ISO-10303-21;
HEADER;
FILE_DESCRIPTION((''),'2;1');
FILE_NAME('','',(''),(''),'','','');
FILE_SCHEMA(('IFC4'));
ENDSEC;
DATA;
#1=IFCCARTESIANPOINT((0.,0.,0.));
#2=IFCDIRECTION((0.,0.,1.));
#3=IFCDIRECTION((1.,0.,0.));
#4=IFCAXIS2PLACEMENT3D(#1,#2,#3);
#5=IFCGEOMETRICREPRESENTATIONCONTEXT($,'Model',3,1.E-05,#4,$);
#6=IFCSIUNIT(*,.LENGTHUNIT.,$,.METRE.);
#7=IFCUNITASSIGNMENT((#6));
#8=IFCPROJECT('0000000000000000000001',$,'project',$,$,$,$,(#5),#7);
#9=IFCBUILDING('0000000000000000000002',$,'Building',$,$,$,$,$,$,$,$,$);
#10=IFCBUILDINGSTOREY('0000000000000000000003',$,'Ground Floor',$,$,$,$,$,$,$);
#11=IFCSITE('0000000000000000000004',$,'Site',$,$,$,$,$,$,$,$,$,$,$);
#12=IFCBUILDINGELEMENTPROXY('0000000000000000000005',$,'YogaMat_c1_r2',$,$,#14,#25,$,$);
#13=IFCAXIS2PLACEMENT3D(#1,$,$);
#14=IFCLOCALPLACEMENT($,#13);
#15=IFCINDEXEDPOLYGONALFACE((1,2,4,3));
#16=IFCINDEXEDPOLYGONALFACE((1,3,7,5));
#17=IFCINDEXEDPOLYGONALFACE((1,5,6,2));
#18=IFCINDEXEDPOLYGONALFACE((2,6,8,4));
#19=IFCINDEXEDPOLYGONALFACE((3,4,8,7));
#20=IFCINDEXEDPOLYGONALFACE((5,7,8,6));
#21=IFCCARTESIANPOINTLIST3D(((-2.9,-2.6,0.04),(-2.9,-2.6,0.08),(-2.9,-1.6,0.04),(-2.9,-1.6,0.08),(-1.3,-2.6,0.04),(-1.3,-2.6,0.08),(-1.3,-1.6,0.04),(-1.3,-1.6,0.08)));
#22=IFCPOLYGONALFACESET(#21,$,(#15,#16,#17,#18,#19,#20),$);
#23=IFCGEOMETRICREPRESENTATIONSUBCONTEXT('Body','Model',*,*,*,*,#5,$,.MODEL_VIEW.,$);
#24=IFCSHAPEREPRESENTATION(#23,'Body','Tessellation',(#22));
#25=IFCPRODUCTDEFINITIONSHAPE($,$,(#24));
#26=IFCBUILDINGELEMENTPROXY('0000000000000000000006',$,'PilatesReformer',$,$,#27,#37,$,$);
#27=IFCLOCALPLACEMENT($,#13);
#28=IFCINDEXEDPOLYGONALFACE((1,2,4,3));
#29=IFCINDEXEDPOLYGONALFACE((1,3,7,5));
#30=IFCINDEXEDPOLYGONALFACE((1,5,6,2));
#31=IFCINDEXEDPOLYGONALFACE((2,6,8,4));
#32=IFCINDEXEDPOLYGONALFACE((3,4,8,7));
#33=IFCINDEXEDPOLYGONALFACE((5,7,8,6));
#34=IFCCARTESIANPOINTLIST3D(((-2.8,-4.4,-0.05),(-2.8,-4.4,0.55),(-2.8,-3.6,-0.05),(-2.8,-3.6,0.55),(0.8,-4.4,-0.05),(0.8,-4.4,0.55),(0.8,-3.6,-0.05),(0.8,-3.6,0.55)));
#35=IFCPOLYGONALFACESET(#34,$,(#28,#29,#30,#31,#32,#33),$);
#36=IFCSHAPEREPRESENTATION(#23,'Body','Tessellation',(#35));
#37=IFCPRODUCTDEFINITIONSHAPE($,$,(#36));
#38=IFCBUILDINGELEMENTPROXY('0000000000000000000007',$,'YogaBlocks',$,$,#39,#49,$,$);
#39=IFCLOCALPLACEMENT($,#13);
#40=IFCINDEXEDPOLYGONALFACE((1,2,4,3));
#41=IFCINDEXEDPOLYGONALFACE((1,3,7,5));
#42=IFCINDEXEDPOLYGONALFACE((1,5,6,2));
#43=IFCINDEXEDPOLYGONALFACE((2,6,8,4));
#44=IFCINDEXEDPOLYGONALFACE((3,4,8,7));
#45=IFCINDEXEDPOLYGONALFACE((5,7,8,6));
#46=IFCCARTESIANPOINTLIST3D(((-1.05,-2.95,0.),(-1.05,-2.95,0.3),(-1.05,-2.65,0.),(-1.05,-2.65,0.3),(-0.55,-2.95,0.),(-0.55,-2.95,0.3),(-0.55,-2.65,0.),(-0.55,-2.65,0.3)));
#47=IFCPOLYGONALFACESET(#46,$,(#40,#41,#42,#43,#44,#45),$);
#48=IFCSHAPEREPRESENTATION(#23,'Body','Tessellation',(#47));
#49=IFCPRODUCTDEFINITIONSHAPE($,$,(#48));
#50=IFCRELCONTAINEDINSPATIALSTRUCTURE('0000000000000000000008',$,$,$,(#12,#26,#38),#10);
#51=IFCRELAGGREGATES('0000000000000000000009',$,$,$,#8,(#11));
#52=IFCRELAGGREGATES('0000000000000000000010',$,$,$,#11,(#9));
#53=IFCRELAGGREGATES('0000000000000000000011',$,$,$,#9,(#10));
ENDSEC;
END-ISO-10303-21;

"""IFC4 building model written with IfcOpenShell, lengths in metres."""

from ifc_helpers import new_model, si_unit, frame, origin_with_axes, origin_2d, place, context, subcontext, project, spatial, rectangle, extrude, element, save


model = new_model("IFC4")

# Units and contexts
model_context = context("Model", 3, precision=1e-05, world=origin_with_axes())
body_context = subcontext(model_context, "Body", "Model", "MODEL_VIEW")
ifc_project = project(units=[si_unit("LENGTHUNIT", "METRE")], contexts=[model_context])

# Site, building, storey
site = spatial("IfcSite", under=ifc_project, Name="Site")
building = spatial("IfcBuilding", under=site, Name="Building")
storey = spatial("IfcBuildingStorey", under=building, Name="Ground Floor")

# Building element proxies
for number, where, z_axis, x_axis, name in (
    (1, (-2.1, -2.1, 0.06), (0.0, 0.0, 1.0), (1.0, 0.0, 0.0), "YogaMat_c1_r2"),
):
    element("IfcBuildingElementProxy", number, at=place(None, frame(where, z_axis=z_axis, x_axis=x_axis)), inside=storey, Name=name, context=body_context, shape_type="SweptSolid", body=[
        extrude(rectangle(XDim=1.6, YDim=1.0, at=origin_2d()), frame((0.0, 0.0, -0.02)), (0.0, 0.0, 1.0), 0.04),
    ])
proxy_1_placement = place(None, frame((-1.0, -4.0, 0.25), z_axis=(0.0, 0.0, 1.0), x_axis=(1.0, 0.0, 0.0)))
element("IfcBuildingElementProxy", 2, at=proxy_1_placement, inside=storey, Name="PilatesReformer", context=body_context, shape_type="SweptSolid", body=[
    extrude(rectangle(XDim=3.6, YDim=0.8, at=origin_2d()), frame((0.0, 0.0, -0.3)), (0.0, 0.0, 1.0), 0.6),
])
proxy_2_placement = place(None, frame((-0.8, -2.8, 0.15), z_axis=(0.0, 0.0, 1.0), x_axis=(1.0, 0.0, 0.0)))
element("IfcBuildingElementProxy", 3, at=proxy_2_placement, inside=storey, Name="YogaBlocks", context=body_context, shape_type="SweptSolid", body=[
    extrude(rectangle(XDim=0.5, YDim=0.3, at=origin_2d()), frame((0.0, 0.0, -0.15)), (0.0, 0.0, 1.0), 0.3),
])

save(model, "model.ifc")
